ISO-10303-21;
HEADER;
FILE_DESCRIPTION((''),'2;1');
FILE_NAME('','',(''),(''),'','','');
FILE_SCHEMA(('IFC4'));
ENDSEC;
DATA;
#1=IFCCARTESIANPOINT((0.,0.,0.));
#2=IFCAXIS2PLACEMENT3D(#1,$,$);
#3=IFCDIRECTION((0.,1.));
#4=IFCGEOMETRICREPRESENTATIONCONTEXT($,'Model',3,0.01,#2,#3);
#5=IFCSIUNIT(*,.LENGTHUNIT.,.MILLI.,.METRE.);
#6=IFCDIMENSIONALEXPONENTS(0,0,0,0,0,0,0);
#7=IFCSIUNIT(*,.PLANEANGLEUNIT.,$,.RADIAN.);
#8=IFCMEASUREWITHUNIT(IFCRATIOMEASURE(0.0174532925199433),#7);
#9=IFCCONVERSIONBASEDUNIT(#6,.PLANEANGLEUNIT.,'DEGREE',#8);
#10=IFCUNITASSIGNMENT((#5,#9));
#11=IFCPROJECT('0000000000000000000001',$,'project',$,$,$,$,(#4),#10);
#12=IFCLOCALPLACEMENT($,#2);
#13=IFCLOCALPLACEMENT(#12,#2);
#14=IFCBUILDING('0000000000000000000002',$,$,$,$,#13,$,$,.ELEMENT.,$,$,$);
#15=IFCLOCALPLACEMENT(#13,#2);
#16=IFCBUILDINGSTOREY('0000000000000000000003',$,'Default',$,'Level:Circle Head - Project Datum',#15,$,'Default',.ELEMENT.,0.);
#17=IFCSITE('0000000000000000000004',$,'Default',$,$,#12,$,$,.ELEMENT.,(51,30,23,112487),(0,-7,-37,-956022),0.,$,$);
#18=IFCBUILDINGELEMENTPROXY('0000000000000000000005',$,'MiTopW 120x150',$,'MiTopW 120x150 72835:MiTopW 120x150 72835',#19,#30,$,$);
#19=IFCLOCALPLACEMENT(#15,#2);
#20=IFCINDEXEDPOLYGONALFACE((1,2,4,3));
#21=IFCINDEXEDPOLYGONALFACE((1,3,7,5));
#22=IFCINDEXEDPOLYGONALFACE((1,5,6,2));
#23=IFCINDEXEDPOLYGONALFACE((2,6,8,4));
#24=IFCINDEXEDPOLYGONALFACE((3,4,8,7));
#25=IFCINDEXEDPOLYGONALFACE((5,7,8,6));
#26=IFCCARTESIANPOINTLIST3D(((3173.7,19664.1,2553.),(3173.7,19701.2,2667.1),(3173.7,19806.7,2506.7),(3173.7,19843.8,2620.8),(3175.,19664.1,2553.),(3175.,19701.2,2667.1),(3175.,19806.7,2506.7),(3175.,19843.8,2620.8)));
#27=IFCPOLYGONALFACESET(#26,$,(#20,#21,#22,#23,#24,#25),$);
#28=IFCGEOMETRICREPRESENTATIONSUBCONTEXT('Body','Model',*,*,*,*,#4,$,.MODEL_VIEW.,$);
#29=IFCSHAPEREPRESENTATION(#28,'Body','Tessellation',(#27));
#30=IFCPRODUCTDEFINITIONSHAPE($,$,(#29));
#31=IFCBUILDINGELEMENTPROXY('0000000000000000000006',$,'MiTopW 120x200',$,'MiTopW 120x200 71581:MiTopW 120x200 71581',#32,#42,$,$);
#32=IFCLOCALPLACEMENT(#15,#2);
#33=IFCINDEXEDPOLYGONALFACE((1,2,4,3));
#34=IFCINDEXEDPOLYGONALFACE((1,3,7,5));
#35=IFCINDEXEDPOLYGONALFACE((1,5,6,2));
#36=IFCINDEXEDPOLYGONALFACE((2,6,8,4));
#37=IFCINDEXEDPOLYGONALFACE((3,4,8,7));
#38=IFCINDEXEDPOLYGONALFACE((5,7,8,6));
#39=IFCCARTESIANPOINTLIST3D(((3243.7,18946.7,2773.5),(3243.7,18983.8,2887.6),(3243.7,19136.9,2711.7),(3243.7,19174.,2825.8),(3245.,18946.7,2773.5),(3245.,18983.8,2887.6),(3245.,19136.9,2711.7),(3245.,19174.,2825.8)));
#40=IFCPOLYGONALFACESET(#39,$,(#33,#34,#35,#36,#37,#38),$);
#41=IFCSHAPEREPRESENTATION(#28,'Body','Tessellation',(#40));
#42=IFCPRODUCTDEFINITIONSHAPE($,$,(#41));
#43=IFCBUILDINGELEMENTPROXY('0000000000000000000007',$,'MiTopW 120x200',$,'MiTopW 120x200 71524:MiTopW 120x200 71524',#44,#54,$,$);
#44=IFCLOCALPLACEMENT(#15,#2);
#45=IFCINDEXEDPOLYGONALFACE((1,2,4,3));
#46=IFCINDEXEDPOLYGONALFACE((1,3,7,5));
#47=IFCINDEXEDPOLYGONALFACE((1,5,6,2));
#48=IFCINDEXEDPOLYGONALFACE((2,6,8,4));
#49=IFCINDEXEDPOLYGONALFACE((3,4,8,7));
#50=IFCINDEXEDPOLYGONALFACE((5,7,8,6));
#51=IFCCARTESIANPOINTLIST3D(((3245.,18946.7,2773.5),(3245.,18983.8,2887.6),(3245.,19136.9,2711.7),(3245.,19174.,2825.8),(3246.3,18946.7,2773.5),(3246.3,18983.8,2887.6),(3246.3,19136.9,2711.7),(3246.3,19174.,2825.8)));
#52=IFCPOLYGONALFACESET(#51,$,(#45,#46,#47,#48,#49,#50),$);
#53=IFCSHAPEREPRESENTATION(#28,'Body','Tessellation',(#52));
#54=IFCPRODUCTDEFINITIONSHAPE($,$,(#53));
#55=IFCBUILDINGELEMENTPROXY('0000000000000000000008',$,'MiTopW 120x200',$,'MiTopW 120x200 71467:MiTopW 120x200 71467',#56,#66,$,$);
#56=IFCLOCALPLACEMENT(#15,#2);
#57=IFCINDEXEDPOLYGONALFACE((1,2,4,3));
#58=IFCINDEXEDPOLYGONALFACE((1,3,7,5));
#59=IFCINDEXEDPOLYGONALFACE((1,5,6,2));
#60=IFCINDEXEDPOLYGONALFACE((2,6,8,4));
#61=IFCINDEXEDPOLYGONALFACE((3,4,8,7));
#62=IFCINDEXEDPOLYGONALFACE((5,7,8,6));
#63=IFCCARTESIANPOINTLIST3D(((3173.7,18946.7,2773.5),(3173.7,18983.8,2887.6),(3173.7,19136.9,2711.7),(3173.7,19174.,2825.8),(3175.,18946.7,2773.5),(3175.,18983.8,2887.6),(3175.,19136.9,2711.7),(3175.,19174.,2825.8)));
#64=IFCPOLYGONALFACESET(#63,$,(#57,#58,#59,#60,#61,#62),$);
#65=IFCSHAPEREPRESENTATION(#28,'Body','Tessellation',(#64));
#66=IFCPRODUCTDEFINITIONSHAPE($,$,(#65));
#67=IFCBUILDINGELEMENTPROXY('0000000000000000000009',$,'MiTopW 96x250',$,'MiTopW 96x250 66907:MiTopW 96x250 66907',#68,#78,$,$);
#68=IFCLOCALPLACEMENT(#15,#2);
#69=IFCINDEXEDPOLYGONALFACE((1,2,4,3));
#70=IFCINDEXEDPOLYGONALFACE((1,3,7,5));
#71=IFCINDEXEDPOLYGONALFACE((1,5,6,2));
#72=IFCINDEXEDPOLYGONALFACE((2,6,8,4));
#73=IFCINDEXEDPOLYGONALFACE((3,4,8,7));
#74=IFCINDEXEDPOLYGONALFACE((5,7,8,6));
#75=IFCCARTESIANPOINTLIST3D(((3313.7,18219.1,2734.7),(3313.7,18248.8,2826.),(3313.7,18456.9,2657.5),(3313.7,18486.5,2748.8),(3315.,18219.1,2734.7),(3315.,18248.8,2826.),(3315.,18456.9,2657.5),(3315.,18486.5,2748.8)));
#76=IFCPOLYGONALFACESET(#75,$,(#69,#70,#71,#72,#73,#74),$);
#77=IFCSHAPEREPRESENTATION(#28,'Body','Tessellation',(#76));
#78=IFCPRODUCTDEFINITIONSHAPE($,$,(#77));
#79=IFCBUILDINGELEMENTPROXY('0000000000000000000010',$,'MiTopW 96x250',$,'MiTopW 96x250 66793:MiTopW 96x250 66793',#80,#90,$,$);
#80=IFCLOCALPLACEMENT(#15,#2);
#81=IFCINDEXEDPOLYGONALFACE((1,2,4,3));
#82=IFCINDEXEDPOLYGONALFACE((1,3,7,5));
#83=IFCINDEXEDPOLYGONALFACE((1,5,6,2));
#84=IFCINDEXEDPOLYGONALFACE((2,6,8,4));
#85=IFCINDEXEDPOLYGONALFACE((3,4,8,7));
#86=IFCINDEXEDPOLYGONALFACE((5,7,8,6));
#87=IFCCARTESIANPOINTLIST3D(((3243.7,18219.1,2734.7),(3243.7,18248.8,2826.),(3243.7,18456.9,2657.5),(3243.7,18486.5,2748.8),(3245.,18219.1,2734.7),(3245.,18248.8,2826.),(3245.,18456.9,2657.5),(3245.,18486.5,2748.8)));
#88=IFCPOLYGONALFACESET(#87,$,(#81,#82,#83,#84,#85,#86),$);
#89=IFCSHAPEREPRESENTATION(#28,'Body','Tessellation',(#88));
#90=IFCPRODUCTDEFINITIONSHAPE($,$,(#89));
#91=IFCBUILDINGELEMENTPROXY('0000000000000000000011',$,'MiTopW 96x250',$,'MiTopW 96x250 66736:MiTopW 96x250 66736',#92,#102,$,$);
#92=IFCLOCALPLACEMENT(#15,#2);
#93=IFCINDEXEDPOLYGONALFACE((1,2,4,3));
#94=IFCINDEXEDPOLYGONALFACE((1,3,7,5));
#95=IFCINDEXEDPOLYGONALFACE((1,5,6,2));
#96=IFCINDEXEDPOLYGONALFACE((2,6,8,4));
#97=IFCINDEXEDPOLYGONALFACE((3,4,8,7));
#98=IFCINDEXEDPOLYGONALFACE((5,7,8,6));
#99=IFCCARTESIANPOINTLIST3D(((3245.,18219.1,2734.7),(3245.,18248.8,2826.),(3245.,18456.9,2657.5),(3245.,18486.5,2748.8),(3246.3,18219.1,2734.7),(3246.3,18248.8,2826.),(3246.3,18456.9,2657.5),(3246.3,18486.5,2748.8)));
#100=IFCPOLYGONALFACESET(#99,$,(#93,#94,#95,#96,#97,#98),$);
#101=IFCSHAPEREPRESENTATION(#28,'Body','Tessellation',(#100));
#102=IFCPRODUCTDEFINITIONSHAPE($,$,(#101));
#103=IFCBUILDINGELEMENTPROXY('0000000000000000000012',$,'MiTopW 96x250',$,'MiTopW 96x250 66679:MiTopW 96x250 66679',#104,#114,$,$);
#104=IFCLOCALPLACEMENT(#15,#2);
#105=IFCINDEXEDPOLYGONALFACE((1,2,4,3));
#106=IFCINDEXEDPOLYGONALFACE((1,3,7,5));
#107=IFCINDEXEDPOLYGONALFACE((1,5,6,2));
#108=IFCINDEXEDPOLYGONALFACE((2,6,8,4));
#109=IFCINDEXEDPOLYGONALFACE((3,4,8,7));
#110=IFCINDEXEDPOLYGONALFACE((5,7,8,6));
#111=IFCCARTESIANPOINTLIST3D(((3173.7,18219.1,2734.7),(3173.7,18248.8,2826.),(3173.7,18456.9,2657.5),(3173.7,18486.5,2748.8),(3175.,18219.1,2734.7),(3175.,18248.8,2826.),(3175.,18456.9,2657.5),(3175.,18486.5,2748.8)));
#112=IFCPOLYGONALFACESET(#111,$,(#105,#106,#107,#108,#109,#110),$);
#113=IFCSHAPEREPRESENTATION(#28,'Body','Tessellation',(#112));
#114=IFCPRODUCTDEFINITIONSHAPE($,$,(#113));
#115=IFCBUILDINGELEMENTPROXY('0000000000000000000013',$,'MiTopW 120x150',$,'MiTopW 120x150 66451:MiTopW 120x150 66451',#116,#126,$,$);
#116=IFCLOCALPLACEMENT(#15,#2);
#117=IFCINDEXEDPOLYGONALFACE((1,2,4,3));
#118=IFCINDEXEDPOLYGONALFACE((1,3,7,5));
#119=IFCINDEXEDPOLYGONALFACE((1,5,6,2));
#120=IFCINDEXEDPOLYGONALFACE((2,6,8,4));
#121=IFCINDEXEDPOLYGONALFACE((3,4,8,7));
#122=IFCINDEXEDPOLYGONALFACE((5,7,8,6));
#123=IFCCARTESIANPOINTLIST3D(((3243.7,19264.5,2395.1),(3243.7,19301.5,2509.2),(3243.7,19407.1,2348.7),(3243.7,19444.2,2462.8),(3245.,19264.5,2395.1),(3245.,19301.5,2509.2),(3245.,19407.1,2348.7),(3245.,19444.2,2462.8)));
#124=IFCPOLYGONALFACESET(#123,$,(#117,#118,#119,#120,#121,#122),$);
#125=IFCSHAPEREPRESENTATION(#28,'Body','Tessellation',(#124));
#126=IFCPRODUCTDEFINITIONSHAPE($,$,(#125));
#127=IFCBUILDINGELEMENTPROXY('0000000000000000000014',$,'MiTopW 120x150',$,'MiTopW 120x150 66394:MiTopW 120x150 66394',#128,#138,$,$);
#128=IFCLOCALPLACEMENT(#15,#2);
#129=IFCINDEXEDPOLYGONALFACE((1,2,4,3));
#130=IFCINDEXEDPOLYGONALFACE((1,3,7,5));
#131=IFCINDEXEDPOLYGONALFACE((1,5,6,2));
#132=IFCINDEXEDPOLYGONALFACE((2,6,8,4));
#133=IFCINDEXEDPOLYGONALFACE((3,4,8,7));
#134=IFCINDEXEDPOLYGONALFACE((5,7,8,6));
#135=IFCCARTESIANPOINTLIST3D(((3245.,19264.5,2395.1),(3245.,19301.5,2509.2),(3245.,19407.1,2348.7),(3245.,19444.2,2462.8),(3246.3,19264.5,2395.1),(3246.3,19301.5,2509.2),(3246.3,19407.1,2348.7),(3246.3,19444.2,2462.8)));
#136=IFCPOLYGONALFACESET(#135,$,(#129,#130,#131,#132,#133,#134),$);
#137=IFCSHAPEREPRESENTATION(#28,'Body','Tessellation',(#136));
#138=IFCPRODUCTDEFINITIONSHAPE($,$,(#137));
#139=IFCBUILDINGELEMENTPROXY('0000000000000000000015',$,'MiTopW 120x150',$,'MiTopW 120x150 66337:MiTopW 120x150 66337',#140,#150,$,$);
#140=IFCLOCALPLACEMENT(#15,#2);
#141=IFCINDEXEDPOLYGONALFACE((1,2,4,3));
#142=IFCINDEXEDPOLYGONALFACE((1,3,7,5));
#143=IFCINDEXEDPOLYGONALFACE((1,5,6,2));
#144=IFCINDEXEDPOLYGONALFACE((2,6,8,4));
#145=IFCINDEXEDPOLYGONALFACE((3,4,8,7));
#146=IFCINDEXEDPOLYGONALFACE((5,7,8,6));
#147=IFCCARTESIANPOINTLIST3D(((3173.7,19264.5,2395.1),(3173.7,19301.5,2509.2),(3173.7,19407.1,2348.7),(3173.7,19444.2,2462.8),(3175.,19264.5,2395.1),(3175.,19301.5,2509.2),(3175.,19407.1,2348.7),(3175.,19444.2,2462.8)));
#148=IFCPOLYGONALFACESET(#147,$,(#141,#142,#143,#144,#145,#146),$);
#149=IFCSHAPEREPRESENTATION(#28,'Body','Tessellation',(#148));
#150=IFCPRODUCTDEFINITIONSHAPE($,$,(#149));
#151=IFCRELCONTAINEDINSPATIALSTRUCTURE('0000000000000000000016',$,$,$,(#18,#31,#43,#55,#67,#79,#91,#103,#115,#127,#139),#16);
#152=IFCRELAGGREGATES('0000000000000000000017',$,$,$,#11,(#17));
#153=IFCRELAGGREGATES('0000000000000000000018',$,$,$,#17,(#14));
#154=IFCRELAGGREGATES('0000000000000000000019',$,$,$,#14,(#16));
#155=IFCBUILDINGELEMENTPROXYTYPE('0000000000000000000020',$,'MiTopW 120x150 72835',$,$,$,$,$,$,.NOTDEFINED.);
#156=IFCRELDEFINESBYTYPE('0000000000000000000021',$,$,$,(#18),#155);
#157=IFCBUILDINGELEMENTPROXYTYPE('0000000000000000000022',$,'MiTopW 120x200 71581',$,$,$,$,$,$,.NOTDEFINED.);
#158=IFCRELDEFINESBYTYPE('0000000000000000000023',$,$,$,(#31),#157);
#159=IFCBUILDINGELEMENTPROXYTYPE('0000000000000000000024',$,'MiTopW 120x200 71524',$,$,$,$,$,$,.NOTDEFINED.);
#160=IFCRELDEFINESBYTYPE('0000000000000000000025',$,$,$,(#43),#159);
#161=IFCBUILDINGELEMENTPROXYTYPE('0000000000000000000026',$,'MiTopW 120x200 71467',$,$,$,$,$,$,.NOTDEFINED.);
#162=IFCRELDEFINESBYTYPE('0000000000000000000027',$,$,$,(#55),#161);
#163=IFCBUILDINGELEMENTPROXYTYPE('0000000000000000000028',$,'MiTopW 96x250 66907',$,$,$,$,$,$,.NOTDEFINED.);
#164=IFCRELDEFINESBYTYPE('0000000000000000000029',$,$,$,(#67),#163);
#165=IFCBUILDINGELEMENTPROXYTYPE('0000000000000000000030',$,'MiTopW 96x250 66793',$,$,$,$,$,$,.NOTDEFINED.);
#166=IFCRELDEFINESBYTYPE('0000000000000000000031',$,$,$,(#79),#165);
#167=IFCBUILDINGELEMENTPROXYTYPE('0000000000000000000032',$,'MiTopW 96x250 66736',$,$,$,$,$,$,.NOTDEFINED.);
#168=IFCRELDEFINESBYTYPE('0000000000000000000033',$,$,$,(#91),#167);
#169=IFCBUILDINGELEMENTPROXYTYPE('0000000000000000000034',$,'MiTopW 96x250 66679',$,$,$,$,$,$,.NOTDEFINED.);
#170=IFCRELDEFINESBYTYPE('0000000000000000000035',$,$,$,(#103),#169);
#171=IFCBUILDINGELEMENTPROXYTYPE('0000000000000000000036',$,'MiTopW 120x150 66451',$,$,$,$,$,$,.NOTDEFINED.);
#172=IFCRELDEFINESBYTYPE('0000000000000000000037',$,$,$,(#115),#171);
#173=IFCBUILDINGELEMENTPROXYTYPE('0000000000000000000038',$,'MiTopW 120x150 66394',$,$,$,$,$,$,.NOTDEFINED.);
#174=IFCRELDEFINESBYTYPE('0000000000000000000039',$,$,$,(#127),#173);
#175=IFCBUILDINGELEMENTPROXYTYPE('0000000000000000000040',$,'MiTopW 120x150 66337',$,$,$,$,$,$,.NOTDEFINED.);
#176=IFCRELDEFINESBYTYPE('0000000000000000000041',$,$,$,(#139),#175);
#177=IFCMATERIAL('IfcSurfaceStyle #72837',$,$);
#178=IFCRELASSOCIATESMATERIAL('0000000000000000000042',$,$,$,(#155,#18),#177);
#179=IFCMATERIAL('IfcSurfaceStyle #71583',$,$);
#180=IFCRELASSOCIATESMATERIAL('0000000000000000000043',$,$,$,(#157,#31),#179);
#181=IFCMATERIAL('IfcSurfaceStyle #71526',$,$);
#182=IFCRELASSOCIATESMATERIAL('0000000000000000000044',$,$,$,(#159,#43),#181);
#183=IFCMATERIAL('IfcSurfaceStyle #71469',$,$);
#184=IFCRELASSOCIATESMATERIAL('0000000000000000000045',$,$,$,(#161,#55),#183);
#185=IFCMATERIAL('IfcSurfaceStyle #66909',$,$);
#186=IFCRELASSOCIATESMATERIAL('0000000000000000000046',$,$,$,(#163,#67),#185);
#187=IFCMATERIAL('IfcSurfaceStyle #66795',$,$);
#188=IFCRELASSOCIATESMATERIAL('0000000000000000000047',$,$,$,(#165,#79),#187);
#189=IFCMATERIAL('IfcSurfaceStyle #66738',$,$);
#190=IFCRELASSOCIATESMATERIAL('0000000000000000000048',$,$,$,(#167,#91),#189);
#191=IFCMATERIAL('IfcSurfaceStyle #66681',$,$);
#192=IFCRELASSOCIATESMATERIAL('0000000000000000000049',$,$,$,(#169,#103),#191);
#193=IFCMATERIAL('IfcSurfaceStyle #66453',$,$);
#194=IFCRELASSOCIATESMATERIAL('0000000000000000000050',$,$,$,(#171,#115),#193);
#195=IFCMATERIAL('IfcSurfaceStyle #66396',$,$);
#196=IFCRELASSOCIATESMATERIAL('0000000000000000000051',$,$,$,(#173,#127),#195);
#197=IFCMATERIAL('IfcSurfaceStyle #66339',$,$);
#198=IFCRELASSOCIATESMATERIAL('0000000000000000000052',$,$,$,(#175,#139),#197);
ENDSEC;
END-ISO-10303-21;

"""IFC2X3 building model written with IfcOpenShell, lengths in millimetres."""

from ifc_helpers import new_model, entity, si_unit, converted_unit, direction, frame, origin, place, context, subcontext, project, spatial, polyline, outline, extrude, source, transform, mapped, material, type_object, type_shapes, element, save


model = new_model("IFC2X3")

# Units and contexts
model_context = context("Model", 3, precision=0.01, world=origin(), true_north=direction((0.0, 1.0)))
body_context = subcontext(model_context, "Body", "Model", "MODEL_VIEW")
ifc_project = project(units=[si_unit("LENGTHUNIT", "METRE", prefix="MILLI"), converted_unit("PLANEANGLEUNIT", "DEGREE", entity("IfcRatioMeasure", 0.0174532925199433), si_unit("PLANEANGLEUNIT", "RADIAN"), dimensions=[0, 0, 0, 0, 0, 0, 0])], contexts=[model_context])

# Site, building, storey
site_placement = place(None, origin())
site = spatial("IfcSite", under=ifc_project, at=site_placement, Name="Default", CompositionType="ELEMENT", RefLatitude=(51, 30, 23, 112487), RefLongitude=(0, -7, -37, -956022), RefElevation=0.0)
building_placement = place(site_placement, origin())
building = spatial("IfcBuilding", under=site, at=building_placement, CompositionType="ELEMENT")
storey_placement = place(building_placement, origin())
storey = spatial("IfcBuildingStorey", under=building, at=storey_placement, Name="Default", ObjectType="Level:Circle Head - Project Datum", LongName="Default", CompositionType="ELEMENT", Elevation=0.0)

# Building element proxies
ifc_material_1 = material(Name="IfcSurfaceStyle #72837")
building_element_proxy_type_1 = type_object("IfcBuildingElementProxyType", Name="MiTopW 120x150 72835", PredefinedType="NOTDEFINED", material=ifc_material_1)
shared_shape_1 = source(origin(), body_context, "Body", "SweptSolid", [
    extrude(outline(polyline([(-75.0, -60.0), (75.0, -60.0), (75.0, 60.0), (-75.0, 60.0), (-75.0, -60.0)])), frame((75.0, 60.0, 0.0), z_axis=(0.0, 0.0, 1.0), x_axis=(-1.0, 0.0, 0.0)), (0.0, 0.0, 1.0), 1.3),
])
type_shapes(building_element_proxy_type_1, [shared_shape_1])
proxy_1_placement = place(building_placement, frame((3175.0, 19806.7, 2506.7), z_axis=(-1.0, 0.0, 0.0), x_axis=(0.0, -0.951057, 0.309017)))
element("IfcBuildingElementProxy", 1, at=proxy_1_placement, inside=storey, type_object=building_element_proxy_type_1, material=ifc_material_1, Name="MiTopW 120x150", ObjectType="MiTopW 120x150 72835:MiTopW 120x150 72835", context=body_context, shape_type="MappedRepresentation", body=[
    mapped(shared_shape_1, transform((0.0, 0.0, 0.0), scale=1.0)),
])
ifc_material_2 = material(Name="IfcSurfaceStyle #71583")
building_element_proxy_type_2 = type_object("IfcBuildingElementProxyType", Name="MiTopW 120x200 71581", PredefinedType="NOTDEFINED", material=ifc_material_2)
shared_shape_2 = source(origin(), body_context, "Body", "SweptSolid", [
    extrude(outline(polyline([(-100.0, -60.0), (100.0, -60.0), (100.0, 60.0), (-100.0, 60.0), (-100.0, -60.0)])), frame((100.0, 60.0, 0.0), z_axis=(0.0, 0.0, 1.0), x_axis=(-1.0, 0.0, 0.0)), (0.0, 0.0, 1.0), 1.3),
])
type_shapes(building_element_proxy_type_2, [shared_shape_2])
proxy_2_placement = place(building_placement, frame((3245.0, 19136.9, 2711.7), z_axis=(-1.0, 0.0, 0.0), x_axis=(0.0, -0.951057, 0.309017)))
element("IfcBuildingElementProxy", 2, at=proxy_2_placement, inside=storey, type_object=building_element_proxy_type_2, material=ifc_material_2, Name="MiTopW 120x200", ObjectType="MiTopW 120x200 71581:MiTopW 120x200 71581", context=body_context, shape_type="MappedRepresentation", body=[
    mapped(shared_shape_2, transform((0.0, 0.0, 0.0), scale=1.0)),
])
ifc_material_3 = material(Name="IfcSurfaceStyle #71526")
building_element_proxy_type_3 = type_object("IfcBuildingElementProxyType", Name="MiTopW 120x200 71524", PredefinedType="NOTDEFINED", material=ifc_material_3)
shared_shape_3 = source(origin(), body_context, "Body", "SweptSolid", [
    extrude(outline(polyline([(-100.0, -60.0), (100.0, -60.0), (100.0, 60.0), (-100.0, 60.0), (-100.0, -60.0)])), frame((100.0, 60.0, 0.0), z_axis=(0.0, 0.0, 1.0), x_axis=(-1.0, 0.0, 0.0)), (0.0, 0.0, 1.0), 1.3),
])
type_shapes(building_element_proxy_type_3, [shared_shape_3])
proxy_3_placement = place(building_placement, frame((3246.3, 19136.9, 2711.7), z_axis=(-1.0, 0.0, 0.0), x_axis=(0.0, -0.951057, 0.309017)))
element("IfcBuildingElementProxy", 3, at=proxy_3_placement, inside=storey, type_object=building_element_proxy_type_3, material=ifc_material_3, Name="MiTopW 120x200", ObjectType="MiTopW 120x200 71524:MiTopW 120x200 71524", context=body_context, shape_type="MappedRepresentation", body=[
    mapped(shared_shape_3, transform((0.0, 0.0, 0.0), scale=1.0)),
])
ifc_material_4 = material(Name="IfcSurfaceStyle #71469")
building_element_proxy_type_4 = type_object("IfcBuildingElementProxyType", Name="MiTopW 120x200 71467", PredefinedType="NOTDEFINED", material=ifc_material_4)
shared_shape_4 = source(origin(), body_context, "Body", "SweptSolid", [
    extrude(outline(polyline([(-100.0, -60.0), (100.0, -60.0), (100.0, 60.0), (-100.0, 60.0), (-100.0, -60.0)])), frame((100.0, 60.0, 0.0), z_axis=(0.0, 0.0, 1.0), x_axis=(-1.0, 0.0, 0.0)), (0.0, 0.0, 1.0), 1.3),
])
type_shapes(building_element_proxy_type_4, [shared_shape_4])
proxy_4_placement = place(building_placement, frame((3175.0, 19136.9, 2711.7), z_axis=(-1.0, 0.0, 0.0), x_axis=(0.0, -0.951057, 0.309017)))
element("IfcBuildingElementProxy", 4, at=proxy_4_placement, inside=storey, type_object=building_element_proxy_type_4, material=ifc_material_4, Name="MiTopW 120x200", ObjectType="MiTopW 120x200 71467:MiTopW 120x200 71467", context=body_context, shape_type="MappedRepresentation", body=[
    mapped(shared_shape_4, transform((0.0, 0.0, 0.0), scale=1.0)),
])
ifc_material_5 = material(Name="IfcSurfaceStyle #66909")
building_element_proxy_type_5 = type_object("IfcBuildingElementProxyType", Name="MiTopW 96x250 66907", PredefinedType="NOTDEFINED", material=ifc_material_5)
shared_shape_5 = source(origin(), body_context, "Body", "SweptSolid", [
    extrude(outline(polyline([(-125.0, -48.0), (125.0, -48.0), (125.0, 48.0), (-125.0, 48.0), (-125.0, -48.0)])), frame((125.0, 48.0, 0.0), z_axis=(0.0, 0.0, 1.0), x_axis=(-1.0, 0.0, 0.0)), (0.0, 0.0, 1.0), 1.3),
])
type_shapes(building_element_proxy_type_5, [shared_shape_5])
proxy_5_placement = place(building_placement, frame((3315.0, 18456.9, 2657.5), z_axis=(-1.0, 0.0, 0.0), x_axis=(0.0, -0.951057, 0.309017)))
element("IfcBuildingElementProxy", 5, at=proxy_5_placement, inside=storey, type_object=building_element_proxy_type_5, material=ifc_material_5, Name="MiTopW 96x250", ObjectType="MiTopW 96x250 66907:MiTopW 96x250 66907", context=body_context, shape_type="MappedRepresentation", body=[
    mapped(shared_shape_5, transform((0.0, 0.0, 0.0), scale=1.0)),
])
ifc_material_6 = material(Name="IfcSurfaceStyle #66795")
building_element_proxy_type_6 = type_object("IfcBuildingElementProxyType", Name="MiTopW 96x250 66793", PredefinedType="NOTDEFINED", material=ifc_material_6)
shared_shape_6 = source(origin(), body_context, "Body", "SweptSolid", [
    extrude(outline(polyline([(-125.0, -48.0), (125.0, -48.0), (125.0, 48.0), (-125.0, 48.0), (-125.0, -48.0)])), frame((125.0, 48.0, 0.0), z_axis=(0.0, 0.0, 1.0), x_axis=(-1.0, 0.0, 0.0)), (0.0, 0.0, 1.0), 1.3),
])
type_shapes(building_element_proxy_type_6, [shared_shape_6])
proxy_6_placement = place(building_placement, frame((3245.0, 18456.9, 2657.5), z_axis=(-1.0, 0.0, 0.0), x_axis=(0.0, -0.951057, 0.309017)))
element("IfcBuildingElementProxy", 6, at=proxy_6_placement, inside=storey, type_object=building_element_proxy_type_6, material=ifc_material_6, Name="MiTopW 96x250", ObjectType="MiTopW 96x250 66793:MiTopW 96x250 66793", context=body_context, shape_type="MappedRepresentation", body=[
    mapped(shared_shape_6, transform((0.0, 0.0, 0.0), scale=1.0)),
])
ifc_material_7 = material(Name="IfcSurfaceStyle #66738")
building_element_proxy_type_7 = type_object("IfcBuildingElementProxyType", Name="MiTopW 96x250 66736", PredefinedType="NOTDEFINED", material=ifc_material_7)
shared_shape_7 = source(origin(), body_context, "Body", "SweptSolid", [
    extrude(outline(polyline([(-125.0, -48.0), (125.0, -48.0), (125.0, 48.0), (-125.0, 48.0), (-125.0, -48.0)])), frame((125.0, 48.0, 0.0), z_axis=(0.0, 0.0, 1.0), x_axis=(-1.0, 0.0, 0.0)), (0.0, 0.0, 1.0), 1.3),
])
type_shapes(building_element_proxy_type_7, [shared_shape_7])
proxy_7_placement = place(building_placement, frame((3246.3, 18456.9, 2657.5), z_axis=(-1.0, 0.0, 0.0), x_axis=(0.0, -0.951057, 0.309017)))
element("IfcBuildingElementProxy", 7, at=proxy_7_placement, inside=storey, type_object=building_element_proxy_type_7, material=ifc_material_7, Name="MiTopW 96x250", ObjectType="MiTopW 96x250 66736:MiTopW 96x250 66736", context=body_context, shape_type="MappedRepresentation", body=[
    mapped(shared_shape_7, transform((0.0, 0.0, 0.0), scale=1.0)),
])
ifc_material_8 = material(Name="IfcSurfaceStyle #66681")
building_element_proxy_type_8 = type_object("IfcBuildingElementProxyType", Name="MiTopW 96x250 66679", PredefinedType="NOTDEFINED", material=ifc_material_8)
shared_shape_8 = source(origin(), body_context, "Body", "SweptSolid", [
    extrude(outline(polyline([(-125.0, -48.0), (125.0, -48.0), (125.0, 48.0), (-125.0, 48.0), (-125.0, -48.0)])), frame((125.0, 48.0, 0.0), z_axis=(0.0, 0.0, 1.0), x_axis=(-1.0, 0.0, 0.0)), (0.0, 0.0, 1.0), 1.3),
])
type_shapes(building_element_proxy_type_8, [shared_shape_8])
proxy_8_placement = place(building_placement, frame((3175.0, 18456.9, 2657.5), z_axis=(-1.0, 0.0, 0.0), x_axis=(0.0, -0.951057, 0.309017)))
element("IfcBuildingElementProxy", 8, at=proxy_8_placement, inside=storey, type_object=building_element_proxy_type_8, material=ifc_material_8, Name="MiTopW 96x250", ObjectType="MiTopW 96x250 66679:MiTopW 96x250 66679", context=body_context, shape_type="MappedRepresentation", body=[
    mapped(shared_shape_8, transform((0.0, 0.0, 0.0), scale=1.0)),
])
ifc_material_9 = material(Name="IfcSurfaceStyle #66453")
building_element_proxy_type_9 = type_object("IfcBuildingElementProxyType", Name="MiTopW 120x150 66451", PredefinedType="NOTDEFINED", material=ifc_material_9)
shared_shape_9 = source(origin(), body_context, "Body", "SweptSolid", [
    extrude(outline(polyline([(-75.0, -60.0), (75.0, -60.0), (75.0, 60.0), (-75.0, 60.0), (-75.0, -60.0)])), frame((75.0, 60.0, 0.0), z_axis=(0.0, 0.0, 1.0), x_axis=(-1.0, 0.0, 0.0)), (0.0, 0.0, 1.0), 1.3),
])
type_shapes(building_element_proxy_type_9, [shared_shape_9])
proxy_9_placement = place(building_placement, frame((3245.0, 19407.1, 2348.7), z_axis=(-1.0, 0.0, 0.0), x_axis=(0.0, -0.951057, 0.309017)))
element("IfcBuildingElementProxy", 9, at=proxy_9_placement, inside=storey, type_object=building_element_proxy_type_9, material=ifc_material_9, Name="MiTopW 120x150", ObjectType="MiTopW 120x150 66451:MiTopW 120x150 66451", context=body_context, shape_type="MappedRepresentation", body=[
    mapped(shared_shape_9, transform((0.0, 0.0, 0.0), scale=1.0)),
])
ifc_material_10 = material(Name="IfcSurfaceStyle #66396")
building_element_proxy_type_10 = type_object("IfcBuildingElementProxyType", Name="MiTopW 120x150 66394", PredefinedType="NOTDEFINED", material=ifc_material_10)
shared_shape_10 = source(origin(), body_context, "Body", "SweptSolid", [
    extrude(outline(polyline([(-75.0, -60.0), (75.0, -60.0), (75.0, 60.0), (-75.0, 60.0), (-75.0, -60.0)])), frame((75.0, 60.0, 0.0), z_axis=(0.0, 0.0, 1.0), x_axis=(-1.0, 0.0, 0.0)), (0.0, 0.0, 1.0), 1.3),
])
type_shapes(building_element_proxy_type_10, [shared_shape_10])
proxy_10_placement = place(building_placement, frame((3246.3, 19407.1, 2348.7), z_axis=(-1.0, 0.0, 0.0), x_axis=(0.0, -0.951057, 0.309017)))
element("IfcBuildingElementProxy", 10, at=proxy_10_placement, inside=storey, type_object=building_element_proxy_type_10, material=ifc_material_10, Name="MiTopW 120x150", ObjectType="MiTopW 120x150 66394:MiTopW 120x150 66394", context=body_context, shape_type="MappedRepresentation", body=[
    mapped(shared_shape_10, transform((0.0, 0.0, 0.0), scale=1.0)),
])
ifc_material_11 = material(Name="IfcSurfaceStyle #66339")
building_element_proxy_type_11 = type_object("IfcBuildingElementProxyType", Name="MiTopW 120x150 66337", PredefinedType="NOTDEFINED", material=ifc_material_11)
shared_shape_11 = source(origin(), body_context, "Body", "SweptSolid", [
    extrude(outline(polyline([(-75.0, -60.0), (75.0, -60.0), (75.0, 60.0), (-75.0, 60.0), (-75.0, -60.0)])), frame((75.0, 60.0, 0.0), z_axis=(0.0, 0.0, 1.0), x_axis=(-1.0, 0.0, 0.0)), (0.0, 0.0, 1.0), 1.3),
])
type_shapes(building_element_proxy_type_11, [shared_shape_11])
proxy_11_placement = place(building_placement, frame((3175.0, 19407.1, 2348.7), z_axis=(-1.0, 0.0, 0.0), x_axis=(0.0, -0.951057, 0.309017)))
element("IfcBuildingElementProxy", 11, at=proxy_11_placement, inside=storey, type_object=building_element_proxy_type_11, material=ifc_material_11, Name="MiTopW 120x150", ObjectType="MiTopW 120x150 66337:MiTopW 120x150 66337", context=body_context, shape_type="MappedRepresentation", body=[
    mapped(shared_shape_11, transform((0.0, 0.0, 0.0), scale=1.0)),
])

save(model, "model.ifc")
